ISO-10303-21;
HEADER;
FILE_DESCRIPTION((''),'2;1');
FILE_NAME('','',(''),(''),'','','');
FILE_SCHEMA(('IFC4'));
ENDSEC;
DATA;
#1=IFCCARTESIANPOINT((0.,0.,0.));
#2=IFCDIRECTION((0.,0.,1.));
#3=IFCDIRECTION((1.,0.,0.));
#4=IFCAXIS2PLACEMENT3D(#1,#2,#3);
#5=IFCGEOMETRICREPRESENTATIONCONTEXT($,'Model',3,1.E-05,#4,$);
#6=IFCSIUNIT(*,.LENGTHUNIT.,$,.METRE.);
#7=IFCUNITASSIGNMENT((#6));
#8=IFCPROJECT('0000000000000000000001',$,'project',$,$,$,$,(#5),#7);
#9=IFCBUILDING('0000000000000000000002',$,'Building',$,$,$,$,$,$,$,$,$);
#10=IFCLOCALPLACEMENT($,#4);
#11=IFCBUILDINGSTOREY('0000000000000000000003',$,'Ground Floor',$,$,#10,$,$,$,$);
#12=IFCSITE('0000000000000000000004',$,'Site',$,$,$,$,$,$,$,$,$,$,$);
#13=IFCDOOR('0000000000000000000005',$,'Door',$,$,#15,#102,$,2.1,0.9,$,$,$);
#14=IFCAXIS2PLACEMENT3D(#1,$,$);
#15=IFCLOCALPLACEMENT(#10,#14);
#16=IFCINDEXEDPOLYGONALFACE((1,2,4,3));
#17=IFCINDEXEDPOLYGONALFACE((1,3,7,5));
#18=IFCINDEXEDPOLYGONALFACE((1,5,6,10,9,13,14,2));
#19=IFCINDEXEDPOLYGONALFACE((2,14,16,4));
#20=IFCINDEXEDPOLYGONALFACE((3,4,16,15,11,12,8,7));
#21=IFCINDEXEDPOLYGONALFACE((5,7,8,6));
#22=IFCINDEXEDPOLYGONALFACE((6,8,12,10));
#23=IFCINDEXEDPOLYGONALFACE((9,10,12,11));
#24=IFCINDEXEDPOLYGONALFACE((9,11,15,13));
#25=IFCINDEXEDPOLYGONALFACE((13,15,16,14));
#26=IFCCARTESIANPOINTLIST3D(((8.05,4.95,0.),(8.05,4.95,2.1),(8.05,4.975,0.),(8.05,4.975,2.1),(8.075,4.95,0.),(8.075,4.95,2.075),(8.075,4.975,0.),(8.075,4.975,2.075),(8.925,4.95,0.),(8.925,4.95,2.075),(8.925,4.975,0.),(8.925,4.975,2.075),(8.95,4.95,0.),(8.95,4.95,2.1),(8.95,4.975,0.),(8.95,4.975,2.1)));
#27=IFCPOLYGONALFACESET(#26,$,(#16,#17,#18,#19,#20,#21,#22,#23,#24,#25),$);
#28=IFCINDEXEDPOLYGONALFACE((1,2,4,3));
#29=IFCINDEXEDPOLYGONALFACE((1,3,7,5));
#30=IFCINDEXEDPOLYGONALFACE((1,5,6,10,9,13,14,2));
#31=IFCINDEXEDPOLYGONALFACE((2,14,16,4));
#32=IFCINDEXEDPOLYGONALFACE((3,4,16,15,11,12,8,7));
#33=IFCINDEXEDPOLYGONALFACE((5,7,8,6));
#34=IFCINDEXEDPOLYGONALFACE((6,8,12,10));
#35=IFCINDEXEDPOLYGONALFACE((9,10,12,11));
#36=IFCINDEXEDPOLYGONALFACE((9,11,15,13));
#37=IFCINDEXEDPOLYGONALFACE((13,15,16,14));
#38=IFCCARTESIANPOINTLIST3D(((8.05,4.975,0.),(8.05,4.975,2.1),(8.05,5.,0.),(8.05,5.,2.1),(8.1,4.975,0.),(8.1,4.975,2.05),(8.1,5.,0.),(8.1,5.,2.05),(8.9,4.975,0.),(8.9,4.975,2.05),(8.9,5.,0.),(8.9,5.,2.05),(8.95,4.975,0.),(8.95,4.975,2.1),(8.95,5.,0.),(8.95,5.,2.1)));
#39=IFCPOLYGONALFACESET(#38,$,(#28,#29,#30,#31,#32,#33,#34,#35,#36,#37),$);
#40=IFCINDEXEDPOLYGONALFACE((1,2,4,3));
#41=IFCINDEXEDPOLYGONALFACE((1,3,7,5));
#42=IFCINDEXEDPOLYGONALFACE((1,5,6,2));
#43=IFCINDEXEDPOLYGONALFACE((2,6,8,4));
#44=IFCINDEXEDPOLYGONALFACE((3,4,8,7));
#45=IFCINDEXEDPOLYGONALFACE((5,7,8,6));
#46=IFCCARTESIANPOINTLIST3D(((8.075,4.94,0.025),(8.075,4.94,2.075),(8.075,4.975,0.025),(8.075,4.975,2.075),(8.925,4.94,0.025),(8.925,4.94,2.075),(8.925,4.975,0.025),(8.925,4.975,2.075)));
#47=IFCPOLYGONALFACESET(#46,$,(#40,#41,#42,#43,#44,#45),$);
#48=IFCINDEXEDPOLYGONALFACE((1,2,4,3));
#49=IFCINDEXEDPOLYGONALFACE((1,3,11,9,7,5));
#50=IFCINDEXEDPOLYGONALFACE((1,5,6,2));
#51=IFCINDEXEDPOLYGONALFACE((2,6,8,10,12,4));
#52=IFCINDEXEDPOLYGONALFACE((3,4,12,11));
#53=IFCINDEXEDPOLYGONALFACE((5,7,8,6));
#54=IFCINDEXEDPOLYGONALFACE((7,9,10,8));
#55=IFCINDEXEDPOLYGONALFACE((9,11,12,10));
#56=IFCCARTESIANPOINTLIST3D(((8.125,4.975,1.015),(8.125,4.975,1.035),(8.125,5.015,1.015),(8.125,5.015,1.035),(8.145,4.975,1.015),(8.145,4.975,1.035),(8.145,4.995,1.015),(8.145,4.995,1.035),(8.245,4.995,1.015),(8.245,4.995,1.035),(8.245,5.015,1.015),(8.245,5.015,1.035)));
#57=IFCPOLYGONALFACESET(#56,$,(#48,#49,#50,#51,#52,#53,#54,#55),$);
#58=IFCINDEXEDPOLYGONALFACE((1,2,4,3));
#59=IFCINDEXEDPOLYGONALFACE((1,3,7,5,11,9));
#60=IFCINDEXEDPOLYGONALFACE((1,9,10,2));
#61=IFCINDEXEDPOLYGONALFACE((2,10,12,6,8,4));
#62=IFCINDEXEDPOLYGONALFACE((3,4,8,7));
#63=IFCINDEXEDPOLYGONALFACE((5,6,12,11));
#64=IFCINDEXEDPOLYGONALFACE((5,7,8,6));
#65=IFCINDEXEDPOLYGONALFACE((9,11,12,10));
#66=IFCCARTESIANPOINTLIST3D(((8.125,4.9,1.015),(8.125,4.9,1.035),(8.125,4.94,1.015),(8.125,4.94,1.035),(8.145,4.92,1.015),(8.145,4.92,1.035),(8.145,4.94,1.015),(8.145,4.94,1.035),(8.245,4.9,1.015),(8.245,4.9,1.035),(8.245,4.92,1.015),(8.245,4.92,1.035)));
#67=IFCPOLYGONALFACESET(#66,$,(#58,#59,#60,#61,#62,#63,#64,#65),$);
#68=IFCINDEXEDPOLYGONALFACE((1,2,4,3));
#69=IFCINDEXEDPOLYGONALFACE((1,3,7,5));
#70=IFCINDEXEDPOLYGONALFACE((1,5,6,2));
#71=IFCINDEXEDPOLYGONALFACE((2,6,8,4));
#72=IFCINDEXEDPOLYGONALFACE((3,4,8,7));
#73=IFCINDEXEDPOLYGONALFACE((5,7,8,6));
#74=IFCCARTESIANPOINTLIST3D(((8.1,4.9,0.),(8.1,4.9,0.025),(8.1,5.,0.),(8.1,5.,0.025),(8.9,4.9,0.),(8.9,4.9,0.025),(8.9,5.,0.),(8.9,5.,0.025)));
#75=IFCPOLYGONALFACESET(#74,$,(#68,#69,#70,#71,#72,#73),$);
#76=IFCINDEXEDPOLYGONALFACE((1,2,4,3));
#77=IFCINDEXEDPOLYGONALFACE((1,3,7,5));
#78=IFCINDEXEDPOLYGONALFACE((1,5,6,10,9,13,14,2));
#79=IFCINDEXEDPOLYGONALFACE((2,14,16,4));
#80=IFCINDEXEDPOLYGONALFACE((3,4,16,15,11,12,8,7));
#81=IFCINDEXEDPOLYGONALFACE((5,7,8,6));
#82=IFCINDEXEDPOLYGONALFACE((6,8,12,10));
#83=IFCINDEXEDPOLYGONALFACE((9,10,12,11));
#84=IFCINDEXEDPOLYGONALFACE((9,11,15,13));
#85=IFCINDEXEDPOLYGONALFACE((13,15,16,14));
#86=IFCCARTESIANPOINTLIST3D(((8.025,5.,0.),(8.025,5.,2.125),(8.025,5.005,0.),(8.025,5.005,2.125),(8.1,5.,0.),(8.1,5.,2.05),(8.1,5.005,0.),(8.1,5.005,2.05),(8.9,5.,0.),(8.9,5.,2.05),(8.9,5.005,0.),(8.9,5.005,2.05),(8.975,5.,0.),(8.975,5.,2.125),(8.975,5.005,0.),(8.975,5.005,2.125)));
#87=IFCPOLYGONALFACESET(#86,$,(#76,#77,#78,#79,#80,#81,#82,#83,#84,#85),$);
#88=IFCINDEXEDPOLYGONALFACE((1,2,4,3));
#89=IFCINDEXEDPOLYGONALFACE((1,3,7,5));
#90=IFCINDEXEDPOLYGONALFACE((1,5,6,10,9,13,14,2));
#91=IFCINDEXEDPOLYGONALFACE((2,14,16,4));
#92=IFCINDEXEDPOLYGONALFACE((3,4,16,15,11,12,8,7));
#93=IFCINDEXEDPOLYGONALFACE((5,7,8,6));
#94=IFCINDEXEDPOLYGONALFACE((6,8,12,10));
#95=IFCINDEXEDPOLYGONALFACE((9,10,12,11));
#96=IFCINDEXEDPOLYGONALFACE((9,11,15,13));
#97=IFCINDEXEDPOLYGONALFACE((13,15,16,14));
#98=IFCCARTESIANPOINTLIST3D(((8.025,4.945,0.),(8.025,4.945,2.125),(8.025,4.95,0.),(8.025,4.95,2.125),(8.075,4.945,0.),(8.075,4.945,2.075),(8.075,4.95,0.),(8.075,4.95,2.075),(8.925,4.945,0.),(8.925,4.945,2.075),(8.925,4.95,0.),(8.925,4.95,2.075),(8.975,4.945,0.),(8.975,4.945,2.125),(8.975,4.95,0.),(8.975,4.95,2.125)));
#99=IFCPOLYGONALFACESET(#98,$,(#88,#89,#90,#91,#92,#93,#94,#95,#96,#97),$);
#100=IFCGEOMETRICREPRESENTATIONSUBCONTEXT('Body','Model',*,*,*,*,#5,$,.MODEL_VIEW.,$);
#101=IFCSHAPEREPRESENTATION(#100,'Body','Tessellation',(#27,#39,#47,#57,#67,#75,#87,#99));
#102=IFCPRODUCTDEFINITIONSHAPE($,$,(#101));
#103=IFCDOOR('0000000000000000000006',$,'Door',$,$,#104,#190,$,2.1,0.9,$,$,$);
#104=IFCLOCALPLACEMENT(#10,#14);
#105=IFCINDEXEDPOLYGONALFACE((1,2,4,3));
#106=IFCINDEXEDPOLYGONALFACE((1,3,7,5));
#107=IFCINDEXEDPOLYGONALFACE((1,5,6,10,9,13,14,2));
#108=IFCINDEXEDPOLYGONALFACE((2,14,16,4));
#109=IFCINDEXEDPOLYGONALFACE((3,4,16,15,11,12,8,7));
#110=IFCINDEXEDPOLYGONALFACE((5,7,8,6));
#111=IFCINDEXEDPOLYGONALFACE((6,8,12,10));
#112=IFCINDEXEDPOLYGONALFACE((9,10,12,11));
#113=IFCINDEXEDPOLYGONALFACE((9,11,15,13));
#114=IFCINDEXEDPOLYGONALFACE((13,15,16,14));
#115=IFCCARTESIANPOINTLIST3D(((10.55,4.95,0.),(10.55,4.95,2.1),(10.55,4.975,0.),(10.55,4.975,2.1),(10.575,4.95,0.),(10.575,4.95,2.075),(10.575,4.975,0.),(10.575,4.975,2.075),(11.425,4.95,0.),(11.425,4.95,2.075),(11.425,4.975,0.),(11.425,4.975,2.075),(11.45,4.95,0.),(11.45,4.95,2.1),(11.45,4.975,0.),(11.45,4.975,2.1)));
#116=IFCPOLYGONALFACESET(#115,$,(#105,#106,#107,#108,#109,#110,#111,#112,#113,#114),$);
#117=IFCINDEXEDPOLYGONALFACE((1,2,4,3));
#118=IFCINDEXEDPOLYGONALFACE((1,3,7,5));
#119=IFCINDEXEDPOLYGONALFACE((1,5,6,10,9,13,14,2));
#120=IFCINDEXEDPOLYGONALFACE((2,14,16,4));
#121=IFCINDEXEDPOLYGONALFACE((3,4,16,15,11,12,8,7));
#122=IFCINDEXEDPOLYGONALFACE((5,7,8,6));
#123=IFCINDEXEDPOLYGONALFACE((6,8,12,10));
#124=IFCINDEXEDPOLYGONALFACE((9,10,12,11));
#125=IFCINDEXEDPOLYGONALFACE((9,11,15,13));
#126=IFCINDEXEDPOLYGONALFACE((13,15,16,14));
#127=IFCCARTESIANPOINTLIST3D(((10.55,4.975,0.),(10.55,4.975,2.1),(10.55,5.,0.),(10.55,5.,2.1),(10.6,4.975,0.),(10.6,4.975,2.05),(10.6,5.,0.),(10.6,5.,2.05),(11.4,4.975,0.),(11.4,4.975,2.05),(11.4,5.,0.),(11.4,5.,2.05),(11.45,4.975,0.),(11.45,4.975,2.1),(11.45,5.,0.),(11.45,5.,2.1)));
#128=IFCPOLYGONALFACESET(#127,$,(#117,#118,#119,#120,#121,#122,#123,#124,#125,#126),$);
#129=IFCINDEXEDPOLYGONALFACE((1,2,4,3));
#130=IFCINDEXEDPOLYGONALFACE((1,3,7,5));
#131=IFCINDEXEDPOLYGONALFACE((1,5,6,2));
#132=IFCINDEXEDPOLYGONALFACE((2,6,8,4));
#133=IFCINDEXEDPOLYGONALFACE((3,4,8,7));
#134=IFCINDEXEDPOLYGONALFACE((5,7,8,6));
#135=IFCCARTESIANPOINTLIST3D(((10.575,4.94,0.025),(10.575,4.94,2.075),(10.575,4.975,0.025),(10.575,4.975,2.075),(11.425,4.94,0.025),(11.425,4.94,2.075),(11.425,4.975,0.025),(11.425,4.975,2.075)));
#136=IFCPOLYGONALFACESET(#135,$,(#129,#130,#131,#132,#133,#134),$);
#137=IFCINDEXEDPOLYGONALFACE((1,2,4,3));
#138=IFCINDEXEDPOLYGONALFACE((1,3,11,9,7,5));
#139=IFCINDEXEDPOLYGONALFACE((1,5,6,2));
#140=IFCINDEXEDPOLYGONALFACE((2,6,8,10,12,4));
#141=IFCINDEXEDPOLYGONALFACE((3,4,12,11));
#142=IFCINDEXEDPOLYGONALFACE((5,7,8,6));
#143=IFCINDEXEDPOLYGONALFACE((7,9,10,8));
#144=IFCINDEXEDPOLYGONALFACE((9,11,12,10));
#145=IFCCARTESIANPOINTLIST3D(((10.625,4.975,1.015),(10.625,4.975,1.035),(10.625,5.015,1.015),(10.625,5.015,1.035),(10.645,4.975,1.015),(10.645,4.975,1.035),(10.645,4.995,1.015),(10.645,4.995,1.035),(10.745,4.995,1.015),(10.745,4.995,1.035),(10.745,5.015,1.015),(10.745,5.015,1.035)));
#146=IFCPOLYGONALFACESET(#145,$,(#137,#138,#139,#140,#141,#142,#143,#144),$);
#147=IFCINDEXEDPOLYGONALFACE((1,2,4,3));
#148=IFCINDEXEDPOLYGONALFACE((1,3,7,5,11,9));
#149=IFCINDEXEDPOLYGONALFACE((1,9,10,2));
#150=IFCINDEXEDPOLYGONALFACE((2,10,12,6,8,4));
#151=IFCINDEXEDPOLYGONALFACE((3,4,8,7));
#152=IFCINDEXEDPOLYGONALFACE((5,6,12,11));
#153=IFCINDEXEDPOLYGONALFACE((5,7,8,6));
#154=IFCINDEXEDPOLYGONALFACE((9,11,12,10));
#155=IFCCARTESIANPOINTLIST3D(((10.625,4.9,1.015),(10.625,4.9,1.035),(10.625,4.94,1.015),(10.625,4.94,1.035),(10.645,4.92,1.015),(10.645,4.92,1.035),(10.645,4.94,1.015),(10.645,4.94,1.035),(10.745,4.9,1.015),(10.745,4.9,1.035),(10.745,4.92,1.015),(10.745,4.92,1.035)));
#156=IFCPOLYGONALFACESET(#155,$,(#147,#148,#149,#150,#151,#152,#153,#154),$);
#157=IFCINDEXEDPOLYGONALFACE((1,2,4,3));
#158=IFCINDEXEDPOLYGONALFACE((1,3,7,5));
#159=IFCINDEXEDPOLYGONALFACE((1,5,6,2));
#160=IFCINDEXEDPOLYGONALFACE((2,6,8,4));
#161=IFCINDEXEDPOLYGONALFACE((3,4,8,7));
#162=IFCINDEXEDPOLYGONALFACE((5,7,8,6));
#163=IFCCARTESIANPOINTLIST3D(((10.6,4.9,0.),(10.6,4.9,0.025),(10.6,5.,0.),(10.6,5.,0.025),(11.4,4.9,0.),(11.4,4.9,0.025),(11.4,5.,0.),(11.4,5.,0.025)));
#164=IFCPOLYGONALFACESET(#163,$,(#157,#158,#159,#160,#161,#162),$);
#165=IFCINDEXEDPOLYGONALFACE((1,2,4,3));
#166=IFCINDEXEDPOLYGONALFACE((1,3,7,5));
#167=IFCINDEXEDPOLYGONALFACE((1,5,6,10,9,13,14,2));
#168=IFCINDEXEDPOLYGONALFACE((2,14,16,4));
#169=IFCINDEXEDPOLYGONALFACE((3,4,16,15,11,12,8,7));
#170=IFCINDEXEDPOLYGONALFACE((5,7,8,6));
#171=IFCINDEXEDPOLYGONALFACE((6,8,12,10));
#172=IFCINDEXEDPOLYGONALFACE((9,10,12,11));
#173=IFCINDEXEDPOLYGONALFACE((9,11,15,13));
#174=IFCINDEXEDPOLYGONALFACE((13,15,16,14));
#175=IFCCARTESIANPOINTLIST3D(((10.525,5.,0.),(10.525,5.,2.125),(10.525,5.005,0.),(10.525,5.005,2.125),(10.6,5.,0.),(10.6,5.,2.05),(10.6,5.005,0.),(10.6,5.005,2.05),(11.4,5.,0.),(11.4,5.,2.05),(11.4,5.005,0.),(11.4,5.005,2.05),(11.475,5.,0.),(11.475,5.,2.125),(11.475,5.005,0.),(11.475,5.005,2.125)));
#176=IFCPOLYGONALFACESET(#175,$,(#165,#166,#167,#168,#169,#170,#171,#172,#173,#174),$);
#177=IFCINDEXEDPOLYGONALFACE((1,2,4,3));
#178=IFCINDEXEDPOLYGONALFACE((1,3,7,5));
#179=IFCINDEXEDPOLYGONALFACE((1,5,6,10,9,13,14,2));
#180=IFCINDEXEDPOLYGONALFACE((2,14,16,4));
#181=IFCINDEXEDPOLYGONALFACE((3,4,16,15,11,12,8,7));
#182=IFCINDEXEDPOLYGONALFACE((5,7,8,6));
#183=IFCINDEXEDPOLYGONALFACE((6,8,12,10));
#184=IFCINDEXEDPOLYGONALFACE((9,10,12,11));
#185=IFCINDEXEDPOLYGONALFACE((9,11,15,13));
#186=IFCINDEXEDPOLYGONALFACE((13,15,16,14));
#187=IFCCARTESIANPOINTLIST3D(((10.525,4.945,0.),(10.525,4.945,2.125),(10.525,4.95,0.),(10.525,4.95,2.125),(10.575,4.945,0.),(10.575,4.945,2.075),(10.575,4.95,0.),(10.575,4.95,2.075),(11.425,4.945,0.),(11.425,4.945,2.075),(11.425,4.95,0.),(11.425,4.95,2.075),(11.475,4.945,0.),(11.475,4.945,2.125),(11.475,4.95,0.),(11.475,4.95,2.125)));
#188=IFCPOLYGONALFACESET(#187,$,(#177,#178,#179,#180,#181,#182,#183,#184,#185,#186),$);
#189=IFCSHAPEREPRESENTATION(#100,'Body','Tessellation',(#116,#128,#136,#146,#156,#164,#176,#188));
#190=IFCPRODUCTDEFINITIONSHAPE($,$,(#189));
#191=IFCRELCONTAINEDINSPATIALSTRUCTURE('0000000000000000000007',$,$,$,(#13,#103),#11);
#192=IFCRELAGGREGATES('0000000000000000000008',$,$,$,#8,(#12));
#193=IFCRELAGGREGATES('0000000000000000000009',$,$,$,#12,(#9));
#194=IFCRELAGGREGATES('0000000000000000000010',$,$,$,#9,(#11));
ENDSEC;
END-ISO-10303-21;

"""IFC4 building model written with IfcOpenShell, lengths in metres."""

from ifc_helpers import new_model, si_unit, frame, origin_with_axes, place, context, subcontext, project, spatial, line, indexed_curve, outline, extrude, element, save


model = new_model("IFC4")

# Units and contexts
model_context = context("Model", 3, precision=1e-05, world=origin_with_axes())
body_context = subcontext(model_context, "Body", "Model", "MODEL_VIEW")
ifc_project = project(units=[si_unit("LENGTHUNIT", "METRE")], contexts=[model_context])

# Site, building, storey
site = spatial("IfcSite", under=ifc_project, Name="Site")
building = spatial("IfcBuilding", under=site, Name="Building")
storey_placement = place(None, origin_with_axes())
storey = spatial("IfcBuildingStorey", under=building, at=storey_placement, Name="Ground Floor")

# Doors
door_1_placement = place(storey_placement, frame((8.95, 5.0, 0.0), z_axis=(0.0, 0.0, 1.0), x_axis=(-1.0, 0.0, 0.0)))
element("IfcDoor", 1, at=door_1_placement, inside=storey, Name="Door", OverallHeight=2.1, OverallWidth=0.9, context=body_context, shape_type="SweptSolid", body=[
    extrude(outline(indexed_curve([(0.0, 0.0), (0.0, 2.1), (0.9, 2.1), (0.9, 0.0), (0.875, 0.0), (0.875, 2.075), (0.025, 2.075), (0.025, 0.0)], segments=[line(1, 2, 3, 4, 5, 6, 7, 8, 1)])), frame((0.0, 0.025, 0.0), z_axis=(0.0, -1.0, 0.0), x_axis=(1.0, 0.0, 0.0)), (0.0, 0.0, -1.0), 0.025),
    extrude(outline(indexed_curve([(0.0, 0.0), (0.0, 2.1), (0.9, 2.1), (0.9, 0.0), (0.85, 0.0), (0.85, 2.05), (0.05, 2.05), (0.05, 0.0)], segments=[line(1, 2, 3, 4, 5, 6, 7, 8, 1)])), frame((0.0, 0.0, 0.0), z_axis=(0.0, -1.0, 0.0), x_axis=(1.0, 0.0, 0.0)), (0.0, 0.0, -1.0), 0.025),
    extrude(outline(indexed_curve([(0.0, 0.0), (0.85, 0.0), (0.85, 0.035), (0.0, 0.035)], segments=[line(1, 2, 3, 4, 1)])), frame((0.025, 0.025, 0.025), z_axis=(0.0, 0.0, 1.0), x_axis=(1.0, 0.0, 0.0)), (0.0, 0.0, 1.0), 2.05),
    extrude(outline(indexed_curve([(0.0, 0.0), (0.0, -0.04), (-0.12, -0.04), (-0.12, -0.02), (-0.02, -0.02), (-0.02, 0.0)], segments=[line(1, 2, 3, 4, 5, 6, 1)])), frame((0.825, 0.025, 1.015), z_axis=(0.0, 0.0, 1.0), x_axis=(1.0, 0.0, 0.0)), (0.0, 0.0, 1.0), 0.02),
    extrude(outline(indexed_curve([(0.0, 0.0), (0.0, 0.04), (-0.12, 0.04), (-0.12, 0.02), (-0.02, 0.02), (-0.02, 0.0)], segments=[line(1, 2, 3, 4, 5, 6, 1)])), frame((0.825, 0.06, 1.015), z_axis=(0.0, 0.0, 1.0), x_axis=(1.0, 0.0, 0.0)), (0.0, 0.0, 1.0), 0.02),
    extrude(outline(indexed_curve([(0.0, 0.0), (0.8, 0.0), (0.8, 0.1), (0.0, 0.1)], segments=[line(1, 2, 3, 4, 1)])), frame((0.05, 0.0, 0.0), z_axis=(0.0, 0.0, 1.0), x_axis=(1.0, 0.0, 0.0)), (0.0, 0.0, 1.0), 0.025),
    extrude(outline(indexed_curve([(0.0, 0.0), (0.0, 2.125), (0.95, 2.125), (0.95, 0.0), (0.875, 0.0), (0.875, 2.05), (0.075, 2.05), (0.075, 0.0)], segments=[line(1, 2, 3, 4, 5, 6, 7, 8, 1)])), frame((-0.025, -0.005, 0.0), z_axis=(0.0, -1.0, 0.0), x_axis=(1.0, 0.0, 0.0)), (0.0, 0.0, -1.0), 0.005),
    extrude(outline(indexed_curve([(0.0, 0.0), (0.0, 2.125), (0.95, 2.125), (0.95, 0.0), (0.9, 0.0), (0.9, 2.075), (0.05, 2.075), (0.05, 0.0)], segments=[line(1, 2, 3, 4, 5, 6, 7, 8, 1)])), frame((-0.025, 0.05, 0.0), z_axis=(0.0, -1.0, 0.0), x_axis=(1.0, 0.0, 0.0)), (0.0, 0.0, -1.0), 0.005),
])
door_2_placement = place(storey_placement, frame((11.45, 5.0, 0.0), z_axis=(0.0, 0.0, 1.0), x_axis=(-1.0, 0.0, 0.0)))
element("IfcDoor", 2, at=door_2_placement, inside=storey, Name="Door", OverallHeight=2.1, OverallWidth=0.9, context=body_context, shape_type="SweptSolid", body=[
    extrude(outline(indexed_curve([(0.0, 0.0), (0.0, 2.1), (0.9, 2.1), (0.9, 0.0), (0.875, 0.0), (0.875, 2.075), (0.025, 2.075), (0.025, 0.0)], segments=[line(1, 2, 3, 4, 5, 6, 7, 8, 1)])), frame((0.0, 0.025, 0.0), z_axis=(0.0, -1.0, 0.0), x_axis=(1.0, 0.0, 0.0)), (0.0, 0.0, -1.0), 0.025),
    extrude(outline(indexed_curve([(0.0, 0.0), (0.0, 2.1), (0.9, 2.1), (0.9, 0.0), (0.85, 0.0), (0.85, 2.05), (0.05, 2.05), (0.05, 0.0)], segments=[line(1, 2, 3, 4, 5, 6, 7, 8, 1)])), frame((0.0, 0.0, 0.0), z_axis=(0.0, -1.0, 0.0), x_axis=(1.0, 0.0, 0.0)), (0.0, 0.0, -1.0), 0.025),
    extrude(outline(indexed_curve([(0.0, 0.0), (0.85, 0.0), (0.85, 0.035), (0.0, 0.035)], segments=[line(1, 2, 3, 4, 1)])), frame((0.025, 0.025, 0.025), z_axis=(0.0, 0.0, 1.0), x_axis=(1.0, 0.0, 0.0)), (0.0, 0.0, 1.0), 2.05),
    extrude(outline(indexed_curve([(0.0, 0.0), (0.0, -0.04), (-0.12, -0.04), (-0.12, -0.02), (-0.02, -0.02), (-0.02, 0.0)], segments=[line(1, 2, 3, 4, 5, 6, 1)])), frame((0.825, 0.025, 1.015), z_axis=(0.0, 0.0, 1.0), x_axis=(1.0, 0.0, 0.0)), (0.0, 0.0, 1.0), 0.02),
    extrude(outline(indexed_curve([(0.0, 0.0), (0.0, 0.04), (-0.12, 0.04), (-0.12, 0.02), (-0.02, 0.02), (-0.02, 0.0)], segments=[line(1, 2, 3, 4, 5, 6, 1)])), frame((0.825, 0.06, 1.015), z_axis=(0.0, 0.0, 1.0), x_axis=(1.0, 0.0, 0.0)), (0.0, 0.0, 1.0), 0.02),
    extrude(outline(indexed_curve([(0.0, 0.0), (0.8, 0.0), (0.8, 0.1), (0.0, 0.1)], segments=[line(1, 2, 3, 4, 1)])), frame((0.05, 0.0, 0.0), z_axis=(0.0, 0.0, 1.0), x_axis=(1.0, 0.0, 0.0)), (0.0, 0.0, 1.0), 0.025),
    extrude(outline(indexed_curve([(0.0, 0.0), (0.0, 2.125), (0.95, 2.125), (0.95, 0.0), (0.875, 0.0), (0.875, 2.05), (0.075, 2.05), (0.075, 0.0)], segments=[line(1, 2, 3, 4, 5, 6, 7, 8, 1)])), frame((-0.025, -0.005, 0.0), z_axis=(0.0, -1.0, 0.0), x_axis=(1.0, 0.0, 0.0)), (0.0, 0.0, -1.0), 0.005),
    extrude(outline(indexed_curve([(0.0, 0.0), (0.0, 2.125), (0.95, 2.125), (0.95, 0.0), (0.9, 0.0), (0.9, 2.075), (0.05, 2.075), (0.05, 0.0)], segments=[line(1, 2, 3, 4, 5, 6, 7, 8, 1)])), frame((-0.025, 0.05, 0.0), z_axis=(0.0, -1.0, 0.0), x_axis=(1.0, 0.0, 0.0)), (0.0, 0.0, -1.0), 0.005),
])

save(model, "model.ifc")
